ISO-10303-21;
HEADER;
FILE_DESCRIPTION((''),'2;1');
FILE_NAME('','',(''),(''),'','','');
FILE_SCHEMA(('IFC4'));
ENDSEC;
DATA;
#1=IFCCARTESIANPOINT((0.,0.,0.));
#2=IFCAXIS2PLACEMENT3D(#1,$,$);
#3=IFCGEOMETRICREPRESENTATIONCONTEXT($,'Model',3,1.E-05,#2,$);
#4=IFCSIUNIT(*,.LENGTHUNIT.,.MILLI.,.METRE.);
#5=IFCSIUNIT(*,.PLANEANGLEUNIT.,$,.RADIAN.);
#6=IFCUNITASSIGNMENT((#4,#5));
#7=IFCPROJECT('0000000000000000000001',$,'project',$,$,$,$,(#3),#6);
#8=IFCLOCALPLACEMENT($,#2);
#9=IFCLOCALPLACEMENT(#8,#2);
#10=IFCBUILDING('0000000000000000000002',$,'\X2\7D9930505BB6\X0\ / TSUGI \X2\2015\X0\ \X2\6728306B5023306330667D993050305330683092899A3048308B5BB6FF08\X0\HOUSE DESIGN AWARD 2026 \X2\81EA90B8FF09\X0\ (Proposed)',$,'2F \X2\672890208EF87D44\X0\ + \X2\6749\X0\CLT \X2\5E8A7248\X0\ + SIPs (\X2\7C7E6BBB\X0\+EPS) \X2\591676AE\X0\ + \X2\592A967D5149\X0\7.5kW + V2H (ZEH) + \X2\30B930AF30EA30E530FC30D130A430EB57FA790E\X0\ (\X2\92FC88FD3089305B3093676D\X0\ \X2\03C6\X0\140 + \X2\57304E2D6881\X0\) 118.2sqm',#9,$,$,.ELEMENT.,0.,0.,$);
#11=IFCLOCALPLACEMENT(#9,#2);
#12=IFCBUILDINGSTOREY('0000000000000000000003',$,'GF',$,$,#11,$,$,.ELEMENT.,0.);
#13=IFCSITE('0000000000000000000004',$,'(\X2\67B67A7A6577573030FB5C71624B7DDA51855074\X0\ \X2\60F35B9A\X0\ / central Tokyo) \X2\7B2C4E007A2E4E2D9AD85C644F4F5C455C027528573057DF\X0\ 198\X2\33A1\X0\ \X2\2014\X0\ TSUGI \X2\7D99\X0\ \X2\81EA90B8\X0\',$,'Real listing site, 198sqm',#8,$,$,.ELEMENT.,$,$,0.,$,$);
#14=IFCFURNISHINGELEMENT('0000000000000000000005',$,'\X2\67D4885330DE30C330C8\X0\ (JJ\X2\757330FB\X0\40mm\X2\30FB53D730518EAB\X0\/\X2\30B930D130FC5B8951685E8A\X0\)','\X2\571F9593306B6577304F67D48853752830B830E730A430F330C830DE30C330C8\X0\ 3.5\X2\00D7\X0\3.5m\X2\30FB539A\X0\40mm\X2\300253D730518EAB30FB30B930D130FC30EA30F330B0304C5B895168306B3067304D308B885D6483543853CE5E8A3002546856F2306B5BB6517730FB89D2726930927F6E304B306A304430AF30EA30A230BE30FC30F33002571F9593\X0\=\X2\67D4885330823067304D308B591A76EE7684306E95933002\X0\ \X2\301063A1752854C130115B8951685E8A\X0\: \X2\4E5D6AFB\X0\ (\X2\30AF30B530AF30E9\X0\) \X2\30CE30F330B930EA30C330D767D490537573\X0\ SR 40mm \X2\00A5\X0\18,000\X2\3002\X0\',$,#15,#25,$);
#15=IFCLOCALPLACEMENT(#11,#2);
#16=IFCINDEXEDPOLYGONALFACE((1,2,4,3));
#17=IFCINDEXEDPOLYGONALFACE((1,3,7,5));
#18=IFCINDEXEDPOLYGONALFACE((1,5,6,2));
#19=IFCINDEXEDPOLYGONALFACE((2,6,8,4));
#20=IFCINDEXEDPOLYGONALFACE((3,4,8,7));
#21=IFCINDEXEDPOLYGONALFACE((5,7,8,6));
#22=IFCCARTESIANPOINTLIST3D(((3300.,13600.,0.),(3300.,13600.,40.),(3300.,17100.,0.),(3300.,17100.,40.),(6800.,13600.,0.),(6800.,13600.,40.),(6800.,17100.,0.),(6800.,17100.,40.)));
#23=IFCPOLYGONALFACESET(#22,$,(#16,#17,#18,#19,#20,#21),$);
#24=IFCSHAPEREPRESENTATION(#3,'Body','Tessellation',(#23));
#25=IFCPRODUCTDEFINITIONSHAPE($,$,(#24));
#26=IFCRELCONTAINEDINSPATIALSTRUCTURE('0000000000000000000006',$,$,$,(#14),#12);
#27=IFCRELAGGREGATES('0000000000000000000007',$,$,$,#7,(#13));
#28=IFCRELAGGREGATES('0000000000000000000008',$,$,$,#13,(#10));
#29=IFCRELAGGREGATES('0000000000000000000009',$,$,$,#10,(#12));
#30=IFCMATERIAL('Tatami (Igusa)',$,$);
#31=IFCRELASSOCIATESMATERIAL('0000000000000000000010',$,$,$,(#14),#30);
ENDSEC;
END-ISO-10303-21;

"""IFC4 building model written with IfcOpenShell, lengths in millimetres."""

from ifc_helpers import new_model, si_unit, frame, frame_2d, origin, place, context, project, spatial, rectangle, extrude, material, element, save


model = new_model("IFC4")

# Units and contexts
model_context = context("Model", 3, precision=1e-05, world=origin())
ifc_project = project(units=[si_unit("LENGTHUNIT", "METRE", prefix="MILLI"), si_unit("PLANEANGLEUNIT", "RADIAN")], contexts=[model_context])

# Site, building, storey
site_placement = place(None, origin())
site = spatial("IfcSite", under=ifc_project, at=site_placement, Name="(架空敷地・山手線内側 想定 / central Tokyo) 第一種中高層住居専用地域 198㎡ — TSUGI 継 自邸", ObjectType="Real listing site, 198sqm", CompositionType="ELEMENT", RefElevation=0.0)
building_placement = place(site_placement, origin())
building = spatial("IfcBuilding", under=site, at=building_placement, Name="継ぐ家 / TSUGI ― 木に倣って継ぐことを覚える家（HOUSE DESIGN AWARD 2026 自邸） (Proposed)", ObjectType="2F 木造軸組 + 杉CLT 床版 + SIPs (籾殻+EPS) 外皮 + 太陽光7.5kW + V2H (ZEH) + スクリューパイル基礎 (鋼製らせん杭 φ140 + 地中梁) 118.2sqm", CompositionType="ELEMENT", ElevationOfRefHeight=0.0, ElevationOfTerrain=0.0)
storey_placement = place(building_placement, origin())
storey = spatial("IfcBuildingStorey", under=building, at=storey_placement, Name="GF", CompositionType="ELEMENT", Elevation=0.0)

# Furnishing element
ifc_material_1 = material(Name="Tatami (Igusa)")
furnishing_1_placement = place(storey_placement, frame((1650.0, 6800.0, 0.0)))
element("IfcFurnishingElement", 1, at=furnishing_1_placement, inside=storey, material=ifc_material_1, Name="柔術マット (JJ畳・40mm・受け身/スパー安全床)", Description="土間に敷く柔術用ジョイントマット 3.5×3.5m・厚40mm。受け身・スパーリングが安全にできる衝撃吸収床。周囲に家具・角物を置かないクリアゾーン。土間=柔術もできる多目的の間。 【採用品】安全床: 九櫻 (クサクラ) ノンスリップ柔道畳 SR 40mm ¥18,000。", context=model_context, shape_type="SweptSolid", body=[
    extrude(rectangle(XDim=3500.0, YDim=3500.0, at=frame_2d((1750.0, 1750.0))), frame((1650.0, 6800.0, 0.0)), (0.0, 0.0, 1.0), 40.0),
])

save(model, "model.ifc")
